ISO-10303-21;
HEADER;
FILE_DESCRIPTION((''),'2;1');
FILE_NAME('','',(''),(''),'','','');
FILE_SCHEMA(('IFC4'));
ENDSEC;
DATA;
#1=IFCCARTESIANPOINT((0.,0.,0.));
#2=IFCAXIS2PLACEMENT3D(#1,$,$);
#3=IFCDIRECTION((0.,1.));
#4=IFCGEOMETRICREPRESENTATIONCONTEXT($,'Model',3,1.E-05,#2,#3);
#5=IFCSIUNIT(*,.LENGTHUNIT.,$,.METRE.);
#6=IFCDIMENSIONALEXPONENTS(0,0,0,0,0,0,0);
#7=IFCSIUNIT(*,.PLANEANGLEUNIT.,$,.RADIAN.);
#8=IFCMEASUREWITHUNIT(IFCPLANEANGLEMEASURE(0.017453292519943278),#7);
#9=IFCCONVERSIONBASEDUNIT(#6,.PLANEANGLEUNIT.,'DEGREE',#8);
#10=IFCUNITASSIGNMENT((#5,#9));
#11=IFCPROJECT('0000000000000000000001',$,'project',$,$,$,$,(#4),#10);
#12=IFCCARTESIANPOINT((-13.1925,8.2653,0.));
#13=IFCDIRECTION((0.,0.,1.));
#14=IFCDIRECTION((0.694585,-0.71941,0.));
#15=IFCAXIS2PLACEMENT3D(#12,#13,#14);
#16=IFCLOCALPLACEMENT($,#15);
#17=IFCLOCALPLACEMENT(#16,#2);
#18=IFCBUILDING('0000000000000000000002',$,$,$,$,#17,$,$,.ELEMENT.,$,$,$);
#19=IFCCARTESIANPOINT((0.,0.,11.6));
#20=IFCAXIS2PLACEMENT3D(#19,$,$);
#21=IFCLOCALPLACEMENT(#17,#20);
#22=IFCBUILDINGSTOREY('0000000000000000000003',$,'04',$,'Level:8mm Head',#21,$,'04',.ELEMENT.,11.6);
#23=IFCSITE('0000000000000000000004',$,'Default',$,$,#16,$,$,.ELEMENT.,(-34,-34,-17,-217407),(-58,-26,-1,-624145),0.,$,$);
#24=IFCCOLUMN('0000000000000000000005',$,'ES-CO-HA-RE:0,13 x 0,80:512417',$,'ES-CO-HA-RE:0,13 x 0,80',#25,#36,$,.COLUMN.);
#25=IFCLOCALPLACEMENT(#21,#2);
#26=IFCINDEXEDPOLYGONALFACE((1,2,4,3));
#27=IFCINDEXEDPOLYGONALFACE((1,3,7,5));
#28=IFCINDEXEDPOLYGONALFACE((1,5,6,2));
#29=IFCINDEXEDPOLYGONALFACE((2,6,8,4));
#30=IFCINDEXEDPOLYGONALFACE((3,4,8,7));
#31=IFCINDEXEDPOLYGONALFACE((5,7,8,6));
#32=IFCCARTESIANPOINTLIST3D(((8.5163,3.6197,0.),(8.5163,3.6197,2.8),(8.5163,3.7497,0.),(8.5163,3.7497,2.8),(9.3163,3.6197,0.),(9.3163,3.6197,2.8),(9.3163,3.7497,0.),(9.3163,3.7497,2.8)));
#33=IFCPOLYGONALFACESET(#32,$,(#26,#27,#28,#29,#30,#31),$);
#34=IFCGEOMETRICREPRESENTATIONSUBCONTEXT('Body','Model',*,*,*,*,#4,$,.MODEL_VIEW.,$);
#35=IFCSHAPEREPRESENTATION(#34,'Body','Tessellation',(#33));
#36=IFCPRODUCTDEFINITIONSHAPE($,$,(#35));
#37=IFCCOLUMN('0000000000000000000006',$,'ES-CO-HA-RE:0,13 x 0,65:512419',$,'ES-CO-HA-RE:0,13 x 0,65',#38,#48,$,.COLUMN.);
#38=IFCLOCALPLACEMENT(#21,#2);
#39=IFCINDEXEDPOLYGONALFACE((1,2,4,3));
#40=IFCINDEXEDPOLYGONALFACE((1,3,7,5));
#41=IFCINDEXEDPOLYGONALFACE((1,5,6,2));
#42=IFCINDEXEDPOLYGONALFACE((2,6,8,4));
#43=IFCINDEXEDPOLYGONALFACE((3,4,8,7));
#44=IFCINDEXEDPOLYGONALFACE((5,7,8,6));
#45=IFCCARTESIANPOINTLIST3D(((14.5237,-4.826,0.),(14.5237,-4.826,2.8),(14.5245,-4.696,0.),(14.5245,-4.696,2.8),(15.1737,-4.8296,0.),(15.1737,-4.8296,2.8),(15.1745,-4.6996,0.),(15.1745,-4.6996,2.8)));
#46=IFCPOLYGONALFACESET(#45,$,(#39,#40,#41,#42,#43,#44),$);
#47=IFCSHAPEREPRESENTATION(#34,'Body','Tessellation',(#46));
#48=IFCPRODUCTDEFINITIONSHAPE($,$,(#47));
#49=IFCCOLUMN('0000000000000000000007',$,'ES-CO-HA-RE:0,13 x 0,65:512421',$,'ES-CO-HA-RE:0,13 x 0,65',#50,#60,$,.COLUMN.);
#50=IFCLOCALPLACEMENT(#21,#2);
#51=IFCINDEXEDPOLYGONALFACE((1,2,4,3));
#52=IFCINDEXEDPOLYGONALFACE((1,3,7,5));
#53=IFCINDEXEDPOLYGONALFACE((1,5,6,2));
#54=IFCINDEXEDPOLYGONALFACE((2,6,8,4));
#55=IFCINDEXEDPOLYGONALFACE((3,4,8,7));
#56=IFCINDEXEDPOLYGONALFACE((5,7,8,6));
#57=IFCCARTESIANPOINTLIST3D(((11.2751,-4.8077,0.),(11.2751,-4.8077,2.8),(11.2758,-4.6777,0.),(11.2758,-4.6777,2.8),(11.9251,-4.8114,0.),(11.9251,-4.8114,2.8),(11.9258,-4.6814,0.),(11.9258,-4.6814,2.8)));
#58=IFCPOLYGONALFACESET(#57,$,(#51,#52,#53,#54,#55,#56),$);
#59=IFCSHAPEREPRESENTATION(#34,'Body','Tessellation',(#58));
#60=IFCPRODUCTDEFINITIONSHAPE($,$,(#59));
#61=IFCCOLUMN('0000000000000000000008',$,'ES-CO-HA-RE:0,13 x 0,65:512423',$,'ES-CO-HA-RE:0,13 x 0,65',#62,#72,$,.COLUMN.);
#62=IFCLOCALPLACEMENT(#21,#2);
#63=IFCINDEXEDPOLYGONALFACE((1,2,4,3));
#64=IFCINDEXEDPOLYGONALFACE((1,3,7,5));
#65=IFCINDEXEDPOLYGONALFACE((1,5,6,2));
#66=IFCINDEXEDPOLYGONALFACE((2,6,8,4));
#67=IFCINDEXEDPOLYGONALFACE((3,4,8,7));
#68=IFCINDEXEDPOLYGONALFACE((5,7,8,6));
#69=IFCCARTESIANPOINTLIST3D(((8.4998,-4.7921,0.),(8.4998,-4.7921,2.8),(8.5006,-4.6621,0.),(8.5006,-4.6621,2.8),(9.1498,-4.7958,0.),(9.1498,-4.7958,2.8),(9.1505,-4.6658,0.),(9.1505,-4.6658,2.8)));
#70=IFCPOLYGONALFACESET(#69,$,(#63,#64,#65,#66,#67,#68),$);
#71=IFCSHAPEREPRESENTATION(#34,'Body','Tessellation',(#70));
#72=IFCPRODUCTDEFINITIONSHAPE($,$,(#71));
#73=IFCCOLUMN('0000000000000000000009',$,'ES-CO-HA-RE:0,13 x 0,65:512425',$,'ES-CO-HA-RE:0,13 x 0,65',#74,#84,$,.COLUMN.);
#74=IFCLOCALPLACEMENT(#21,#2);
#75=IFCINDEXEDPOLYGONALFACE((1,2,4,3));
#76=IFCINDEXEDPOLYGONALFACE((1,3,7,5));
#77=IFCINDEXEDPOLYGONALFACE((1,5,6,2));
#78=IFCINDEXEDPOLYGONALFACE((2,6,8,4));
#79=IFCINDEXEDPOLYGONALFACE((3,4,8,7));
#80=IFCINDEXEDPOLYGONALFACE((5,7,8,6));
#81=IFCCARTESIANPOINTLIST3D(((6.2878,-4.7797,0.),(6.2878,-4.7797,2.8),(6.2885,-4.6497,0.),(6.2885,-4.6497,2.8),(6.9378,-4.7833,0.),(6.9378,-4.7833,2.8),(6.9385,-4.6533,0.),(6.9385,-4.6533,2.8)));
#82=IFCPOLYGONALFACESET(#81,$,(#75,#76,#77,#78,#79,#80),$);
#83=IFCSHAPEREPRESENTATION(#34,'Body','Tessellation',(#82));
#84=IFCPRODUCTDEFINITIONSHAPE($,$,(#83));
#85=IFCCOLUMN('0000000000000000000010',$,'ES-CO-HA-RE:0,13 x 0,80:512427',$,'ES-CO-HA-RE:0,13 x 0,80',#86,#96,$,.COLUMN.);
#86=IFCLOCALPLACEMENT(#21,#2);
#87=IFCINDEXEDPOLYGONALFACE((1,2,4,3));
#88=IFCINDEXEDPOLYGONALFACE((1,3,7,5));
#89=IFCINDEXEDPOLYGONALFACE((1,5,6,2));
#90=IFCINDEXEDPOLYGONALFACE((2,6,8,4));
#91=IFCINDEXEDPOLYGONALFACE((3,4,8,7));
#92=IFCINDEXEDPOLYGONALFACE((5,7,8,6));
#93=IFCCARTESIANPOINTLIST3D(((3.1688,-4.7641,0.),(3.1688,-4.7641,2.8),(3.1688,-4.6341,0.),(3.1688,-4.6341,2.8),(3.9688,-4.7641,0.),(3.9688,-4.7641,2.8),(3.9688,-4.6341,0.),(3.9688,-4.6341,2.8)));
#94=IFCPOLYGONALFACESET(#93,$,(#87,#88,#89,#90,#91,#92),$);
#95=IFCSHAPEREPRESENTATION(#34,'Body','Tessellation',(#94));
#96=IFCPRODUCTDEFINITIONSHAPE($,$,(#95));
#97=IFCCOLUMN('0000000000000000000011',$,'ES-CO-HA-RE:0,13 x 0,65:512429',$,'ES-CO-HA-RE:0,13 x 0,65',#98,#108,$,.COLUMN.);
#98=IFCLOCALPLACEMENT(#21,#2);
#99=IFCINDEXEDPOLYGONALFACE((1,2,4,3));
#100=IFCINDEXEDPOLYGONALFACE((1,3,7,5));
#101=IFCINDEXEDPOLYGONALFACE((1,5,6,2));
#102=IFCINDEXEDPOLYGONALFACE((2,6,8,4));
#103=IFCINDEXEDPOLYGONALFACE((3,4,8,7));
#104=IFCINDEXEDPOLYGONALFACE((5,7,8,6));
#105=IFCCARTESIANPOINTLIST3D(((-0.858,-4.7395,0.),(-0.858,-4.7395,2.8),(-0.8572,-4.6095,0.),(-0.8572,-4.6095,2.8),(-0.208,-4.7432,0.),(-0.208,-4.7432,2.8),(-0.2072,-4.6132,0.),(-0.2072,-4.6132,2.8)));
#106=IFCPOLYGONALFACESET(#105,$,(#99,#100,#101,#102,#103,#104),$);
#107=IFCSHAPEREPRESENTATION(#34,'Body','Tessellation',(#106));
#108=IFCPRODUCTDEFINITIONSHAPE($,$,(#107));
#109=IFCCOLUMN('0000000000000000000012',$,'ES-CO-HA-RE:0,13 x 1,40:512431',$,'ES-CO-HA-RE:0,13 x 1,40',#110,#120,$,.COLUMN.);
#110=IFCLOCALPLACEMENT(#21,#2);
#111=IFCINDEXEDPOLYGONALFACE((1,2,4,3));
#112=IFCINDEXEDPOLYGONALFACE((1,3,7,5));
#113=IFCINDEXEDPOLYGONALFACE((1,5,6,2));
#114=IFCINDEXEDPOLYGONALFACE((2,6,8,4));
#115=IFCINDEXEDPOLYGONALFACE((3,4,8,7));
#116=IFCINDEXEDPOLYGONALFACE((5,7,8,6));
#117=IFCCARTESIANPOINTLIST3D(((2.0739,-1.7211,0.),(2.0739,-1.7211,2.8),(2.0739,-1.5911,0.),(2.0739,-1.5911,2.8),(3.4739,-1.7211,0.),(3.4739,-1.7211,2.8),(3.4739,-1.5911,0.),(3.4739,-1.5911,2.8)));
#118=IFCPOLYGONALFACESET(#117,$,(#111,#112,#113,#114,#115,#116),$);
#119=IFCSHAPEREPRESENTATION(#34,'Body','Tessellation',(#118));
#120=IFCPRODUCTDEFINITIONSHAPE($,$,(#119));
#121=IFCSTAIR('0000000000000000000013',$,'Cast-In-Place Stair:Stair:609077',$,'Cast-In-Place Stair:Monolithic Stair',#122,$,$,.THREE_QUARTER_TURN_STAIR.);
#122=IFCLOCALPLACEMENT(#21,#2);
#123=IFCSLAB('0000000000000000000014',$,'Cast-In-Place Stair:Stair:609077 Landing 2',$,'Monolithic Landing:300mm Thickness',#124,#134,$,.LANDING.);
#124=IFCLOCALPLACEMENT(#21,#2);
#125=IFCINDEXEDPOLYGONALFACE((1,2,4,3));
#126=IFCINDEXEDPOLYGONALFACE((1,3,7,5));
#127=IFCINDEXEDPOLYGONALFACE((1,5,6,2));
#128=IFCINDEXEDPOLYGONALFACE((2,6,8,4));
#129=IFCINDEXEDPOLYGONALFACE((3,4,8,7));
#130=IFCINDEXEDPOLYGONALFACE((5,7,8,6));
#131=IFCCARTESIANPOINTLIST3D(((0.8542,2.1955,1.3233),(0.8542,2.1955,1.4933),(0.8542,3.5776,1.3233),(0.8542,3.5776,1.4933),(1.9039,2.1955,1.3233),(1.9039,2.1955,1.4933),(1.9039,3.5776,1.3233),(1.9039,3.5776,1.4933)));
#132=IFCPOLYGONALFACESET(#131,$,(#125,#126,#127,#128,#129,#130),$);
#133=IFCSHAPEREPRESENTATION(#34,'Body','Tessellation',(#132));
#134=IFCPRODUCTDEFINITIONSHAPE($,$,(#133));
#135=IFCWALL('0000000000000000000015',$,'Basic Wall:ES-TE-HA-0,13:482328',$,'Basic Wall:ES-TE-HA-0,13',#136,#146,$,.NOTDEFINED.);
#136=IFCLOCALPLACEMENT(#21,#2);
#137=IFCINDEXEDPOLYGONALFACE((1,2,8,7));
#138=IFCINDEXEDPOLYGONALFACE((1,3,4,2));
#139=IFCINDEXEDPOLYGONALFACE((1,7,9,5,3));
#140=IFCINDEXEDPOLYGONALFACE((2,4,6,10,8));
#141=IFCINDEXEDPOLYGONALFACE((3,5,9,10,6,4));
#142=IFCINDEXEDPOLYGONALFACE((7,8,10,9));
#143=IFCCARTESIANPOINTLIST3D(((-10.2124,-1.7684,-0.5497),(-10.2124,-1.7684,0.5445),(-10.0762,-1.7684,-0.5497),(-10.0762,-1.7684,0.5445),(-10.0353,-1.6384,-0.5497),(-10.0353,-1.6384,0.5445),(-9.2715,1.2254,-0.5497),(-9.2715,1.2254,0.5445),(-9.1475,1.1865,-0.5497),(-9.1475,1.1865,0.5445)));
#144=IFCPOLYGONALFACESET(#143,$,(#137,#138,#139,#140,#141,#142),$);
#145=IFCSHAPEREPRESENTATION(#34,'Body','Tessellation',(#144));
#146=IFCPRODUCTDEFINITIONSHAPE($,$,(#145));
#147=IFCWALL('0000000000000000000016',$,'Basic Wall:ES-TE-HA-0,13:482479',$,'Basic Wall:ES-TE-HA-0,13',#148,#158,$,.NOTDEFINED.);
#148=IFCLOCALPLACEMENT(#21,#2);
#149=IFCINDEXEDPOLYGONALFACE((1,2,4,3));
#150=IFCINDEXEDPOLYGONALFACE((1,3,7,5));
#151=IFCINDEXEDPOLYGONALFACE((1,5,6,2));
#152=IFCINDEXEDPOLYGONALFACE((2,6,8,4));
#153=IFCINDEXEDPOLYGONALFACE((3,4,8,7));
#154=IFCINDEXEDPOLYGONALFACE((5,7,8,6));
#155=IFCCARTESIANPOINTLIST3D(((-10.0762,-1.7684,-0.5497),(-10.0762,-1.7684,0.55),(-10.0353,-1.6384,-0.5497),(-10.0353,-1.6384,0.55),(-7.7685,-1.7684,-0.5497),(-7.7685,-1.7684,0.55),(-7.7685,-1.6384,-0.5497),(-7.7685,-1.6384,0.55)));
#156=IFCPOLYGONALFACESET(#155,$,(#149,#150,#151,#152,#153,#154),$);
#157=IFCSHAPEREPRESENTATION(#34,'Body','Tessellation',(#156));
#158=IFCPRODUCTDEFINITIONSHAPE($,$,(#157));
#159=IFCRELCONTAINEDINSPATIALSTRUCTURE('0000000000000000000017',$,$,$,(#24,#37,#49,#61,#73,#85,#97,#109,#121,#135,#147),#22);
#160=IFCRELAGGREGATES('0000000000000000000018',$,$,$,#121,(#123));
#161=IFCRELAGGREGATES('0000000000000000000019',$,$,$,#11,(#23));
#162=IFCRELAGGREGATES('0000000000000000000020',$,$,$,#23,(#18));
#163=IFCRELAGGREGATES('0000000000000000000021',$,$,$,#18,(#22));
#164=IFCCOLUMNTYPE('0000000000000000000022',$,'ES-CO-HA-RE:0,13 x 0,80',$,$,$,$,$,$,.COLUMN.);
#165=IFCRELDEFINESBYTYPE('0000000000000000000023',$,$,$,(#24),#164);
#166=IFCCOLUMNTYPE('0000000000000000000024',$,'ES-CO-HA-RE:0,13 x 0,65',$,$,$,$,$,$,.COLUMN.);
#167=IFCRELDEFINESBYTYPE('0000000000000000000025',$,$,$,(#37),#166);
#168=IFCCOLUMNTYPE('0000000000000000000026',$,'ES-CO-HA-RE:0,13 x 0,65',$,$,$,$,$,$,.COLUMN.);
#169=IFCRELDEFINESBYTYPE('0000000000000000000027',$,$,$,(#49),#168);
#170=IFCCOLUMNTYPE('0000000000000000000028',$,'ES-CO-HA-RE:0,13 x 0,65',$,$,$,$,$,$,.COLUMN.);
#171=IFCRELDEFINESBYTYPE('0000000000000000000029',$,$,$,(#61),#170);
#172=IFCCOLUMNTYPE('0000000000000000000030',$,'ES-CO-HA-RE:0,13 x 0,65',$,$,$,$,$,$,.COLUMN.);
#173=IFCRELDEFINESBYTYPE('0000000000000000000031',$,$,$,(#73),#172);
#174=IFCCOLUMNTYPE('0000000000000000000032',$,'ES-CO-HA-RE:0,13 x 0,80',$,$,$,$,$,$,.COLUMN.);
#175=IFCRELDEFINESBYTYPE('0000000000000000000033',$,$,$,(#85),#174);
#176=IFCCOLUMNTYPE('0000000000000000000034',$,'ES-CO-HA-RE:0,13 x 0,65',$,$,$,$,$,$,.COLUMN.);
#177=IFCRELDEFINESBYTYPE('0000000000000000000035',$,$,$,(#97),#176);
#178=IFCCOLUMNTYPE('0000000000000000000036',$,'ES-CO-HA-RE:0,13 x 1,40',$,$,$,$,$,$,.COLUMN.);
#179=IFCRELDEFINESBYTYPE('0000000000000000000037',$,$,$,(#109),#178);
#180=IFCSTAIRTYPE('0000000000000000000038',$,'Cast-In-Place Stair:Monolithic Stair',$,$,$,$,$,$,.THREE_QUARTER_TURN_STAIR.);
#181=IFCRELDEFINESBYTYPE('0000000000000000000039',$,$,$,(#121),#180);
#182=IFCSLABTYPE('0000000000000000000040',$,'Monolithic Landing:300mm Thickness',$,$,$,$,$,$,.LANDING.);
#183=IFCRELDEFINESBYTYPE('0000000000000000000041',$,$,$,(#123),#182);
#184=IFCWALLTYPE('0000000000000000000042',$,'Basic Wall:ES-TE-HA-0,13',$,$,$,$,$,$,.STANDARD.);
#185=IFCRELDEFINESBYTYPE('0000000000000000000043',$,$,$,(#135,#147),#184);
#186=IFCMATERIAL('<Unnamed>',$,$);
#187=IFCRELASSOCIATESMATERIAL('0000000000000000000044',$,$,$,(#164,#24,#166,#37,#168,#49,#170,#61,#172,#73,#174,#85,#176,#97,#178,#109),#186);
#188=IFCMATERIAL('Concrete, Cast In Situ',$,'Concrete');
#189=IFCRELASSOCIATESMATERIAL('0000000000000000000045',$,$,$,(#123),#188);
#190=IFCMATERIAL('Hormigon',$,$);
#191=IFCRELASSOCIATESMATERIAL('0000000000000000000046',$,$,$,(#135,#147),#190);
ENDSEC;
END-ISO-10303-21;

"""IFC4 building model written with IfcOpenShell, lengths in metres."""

from ifc_helpers import new_model, entity, si_unit, converted_unit, direction, frame, origin, place, context, subcontext, project, spatial, indexed_curve, outline, extrude, source, transform, mapped, material, type_object, type_shapes, element, aggregate, save


model = new_model("IFC4")

# Units and contexts
model_context = context("Model", 3, precision=1e-05, world=origin(), true_north=direction((0.0, 1.0)))
body_context = subcontext(model_context, "Body", "Model", "MODEL_VIEW")
ifc_project = project(units=[si_unit("LENGTHUNIT", "METRE"), converted_unit("PLANEANGLEUNIT", "DEGREE", entity("IfcPlaneAngleMeasure", 0.017453292519943278), si_unit("PLANEANGLEUNIT", "RADIAN"), dimensions=[0, 0, 0, 0, 0, 0, 0])], contexts=[model_context])

# Site, building, storey
site_placement = place(None, frame((-13.1925, 8.2653, 0.0), z_axis=(0.0, 0.0, 1.0), x_axis=(0.694585, -0.71941, 0.0)))
site = spatial("IfcSite", under=ifc_project, at=site_placement, Name="Default", CompositionType="ELEMENT", RefLatitude=(-34, -34, -17, -217407), RefLongitude=(-58, -26, -1, -624145), RefElevation=0.0)
building_placement = place(site_placement, origin())
building = spatial("IfcBuilding", under=site, at=building_placement, CompositionType="ELEMENT")
storey_placement = place(building_placement, frame((0.0, 0.0, 11.6)))
storey = spatial("IfcBuildingStorey", under=building, at=storey_placement, Name="04", ObjectType="Level:8mm Head", LongName="04", CompositionType="ELEMENT", Elevation=11.6)

# Columns
ifc_material_1 = material(Name="<Unnamed>")
ifc_material_2 = material(Name="Hormigon")
column_type_1 = type_object("IfcColumnType", Name="ES-CO-HA-RE:0,13 x 0,80", PredefinedType="COLUMN", material=ifc_material_1)
shared_shape_1 = source(origin(), body_context, "Body", "SweptSolid", [
    extrude(outline(indexed_curve([(-0.4, -0.065), (0.4, -0.065), (0.4, 0.065), (-0.4, 0.065), (-0.4, -0.065)], self_intersect=False)), frame((8.9163, 3.6847, 11.6), z_axis=(0.0, 0.0, 1.0), x_axis=(-1.0, 0.0, 0.0)), (0.0, 0.0, 1.0), 2.8),
])
type_shapes(column_type_1, [shared_shape_1])
column_1_placement = place(storey_placement, frame((0.0, 0.0, -11.6)))
element("IfcColumn", 1, at=column_1_placement, inside=storey, type_object=column_type_1, material=ifc_material_1, Name="ES-CO-HA-RE:0,13 x 0,80:512417", ObjectType="ES-CO-HA-RE:0,13 x 0,80", PredefinedType="COLUMN", context=body_context, shape_type="MappedRepresentation", body=[
    mapped(shared_shape_1, transform((0.0, 0.0, 0.0), scale=1.0)),
])
column_type_2 = type_object("IfcColumnType", Name="ES-CO-HA-RE:0,13 x 0,65", PredefinedType="COLUMN", material=ifc_material_1)
shared_shape_2 = source(origin(), body_context, "Body", "SweptSolid", [
    extrude(outline(indexed_curve([(-0.325, -0.065), (0.325, -0.065), (0.325, 0.065), (-0.325, 0.065), (-0.325, -0.065)], self_intersect=False)), frame((14.8491, -4.7628, 11.6), z_axis=(0.0, 0.0, 1.0), x_axis=(-0.999984, 0.005619, 0.0)), (0.0, 0.0, 1.0), 2.8),
])
type_shapes(column_type_2, [shared_shape_2])
column_2_placement = place(storey_placement, frame((0.0, 0.0, -11.6)))
element("IfcColumn", 2, at=column_2_placement, inside=storey, type_object=column_type_2, material=ifc_material_1, Name="ES-CO-HA-RE:0,13 x 0,65:512419", ObjectType="ES-CO-HA-RE:0,13 x 0,65", PredefinedType="COLUMN", context=body_context, shape_type="MappedRepresentation", body=[
    mapped(shared_shape_2, transform((0.0, 0.0, 0.0), scale=1.0)),
])
column_type_3 = type_object("IfcColumnType", Name="ES-CO-HA-RE:0,13 x 0,65", PredefinedType="COLUMN", material=ifc_material_1)
shared_shape_3 = source(origin(), body_context, "Body", "SweptSolid", [
    extrude(outline(indexed_curve([(-0.325, -0.065), (0.325, -0.065), (0.325, 0.065), (-0.325, 0.065), (-0.325, -0.065)], self_intersect=False)), frame((11.6005, -4.7445, 11.6), z_axis=(0.0, 0.0, 1.0), x_axis=(-0.999984, 0.005619, 0.0)), (0.0, 0.0, 1.0), 2.8),
])
type_shapes(column_type_3, [shared_shape_3])
column_3_placement = place(storey_placement, frame((0.0, 0.0, -11.6)))
element("IfcColumn", 3, at=column_3_placement, inside=storey, type_object=column_type_3, material=ifc_material_1, Name="ES-CO-HA-RE:0,13 x 0,65:512421", ObjectType="ES-CO-HA-RE:0,13 x 0,65", PredefinedType="COLUMN", context=body_context, shape_type="MappedRepresentation", body=[
    mapped(shared_shape_3, transform((0.0, 0.0, 0.0), scale=1.0)),
])
column_type_4 = type_object("IfcColumnType", Name="ES-CO-HA-RE:0,13 x 0,65", PredefinedType="COLUMN", material=ifc_material_1)
shared_shape_4 = source(origin(), body_context, "Body", "SweptSolid", [
    extrude(outline(indexed_curve([(-0.325, -0.065), (0.325, -0.065), (0.325, 0.065), (-0.325, 0.065), (-0.325, -0.065)], self_intersect=False)), frame((8.8252, -4.7289, 11.6), z_axis=(0.0, 0.0, 1.0), x_axis=(-0.999984, 0.005619, 0.0)), (0.0, 0.0, 1.0), 2.8),
])
type_shapes(column_type_4, [shared_shape_4])
column_4_placement = place(storey_placement, frame((0.0, 0.0, -11.6)))
element("IfcColumn", 4, at=column_4_placement, inside=storey, type_object=column_type_4, material=ifc_material_1, Name="ES-CO-HA-RE:0,13 x 0,65:512423", ObjectType="ES-CO-HA-RE:0,13 x 0,65", PredefinedType="COLUMN", context=body_context, shape_type="MappedRepresentation", body=[
    mapped(shared_shape_4, transform((0.0, 0.0, 0.0), scale=1.0)),
])
column_type_5 = type_object("IfcColumnType", Name="ES-CO-HA-RE:0,13 x 0,65", PredefinedType="COLUMN", material=ifc_material_1)
shared_shape_5 = source(origin(), body_context, "Body", "SweptSolid", [
    extrude(outline(indexed_curve([(-0.325, -0.065), (0.325, -0.065), (0.325, 0.065), (-0.325, 0.065), (-0.325, -0.065)], self_intersect=False)), frame((6.6131, -4.7165, 11.6), z_axis=(0.0, 0.0, 1.0), x_axis=(-0.999984, 0.005619, 0.0)), (0.0, 0.0, 1.0), 2.8),
])
type_shapes(column_type_5, [shared_shape_5])
column_5_placement = place(storey_placement, frame((0.0, 0.0, -11.6)))
element("IfcColumn", 5, at=column_5_placement, inside=storey, type_object=column_type_5, material=ifc_material_1, Name="ES-CO-HA-RE:0,13 x 0,65:512425", ObjectType="ES-CO-HA-RE:0,13 x 0,65", PredefinedType="COLUMN", context=body_context, shape_type="MappedRepresentation", body=[
    mapped(shared_shape_5, transform((0.0, 0.0, 0.0), scale=1.0)),
])
column_type_6 = type_object("IfcColumnType", Name="ES-CO-HA-RE:0,13 x 0,80", PredefinedType="COLUMN", material=ifc_material_1)
shared_shape_6 = source(origin(), body_context, "Body", "SweptSolid", [
    extrude(outline(indexed_curve([(-0.4, -0.065), (0.4, -0.065), (0.4, 0.065), (-0.4, 0.065), (-0.4, -0.065)], self_intersect=False)), frame((3.5688, -4.6991, 11.6), z_axis=(0.0, 0.0, 1.0), x_axis=(-1.0, 0.0, 0.0)), (0.0, 0.0, 1.0), 2.8),
])
type_shapes(column_type_6, [shared_shape_6])
column_6_placement = place(storey_placement, frame((0.0, 0.0, -11.6)))
element("IfcColumn", 6, at=column_6_placement, inside=storey, type_object=column_type_6, material=ifc_material_1, Name="ES-CO-HA-RE:0,13 x 0,80:512427", ObjectType="ES-CO-HA-RE:0,13 x 0,80", PredefinedType="COLUMN", context=body_context, shape_type="MappedRepresentation", body=[
    mapped(shared_shape_6, transform((0.0, 0.0, 0.0), scale=1.0)),
])
column_type_7 = type_object("IfcColumnType", Name="ES-CO-HA-RE:0,13 x 0,65", PredefinedType="COLUMN", material=ifc_material_1)
shared_shape_7 = source(origin(), body_context, "Body", "SweptSolid", [
    extrude(outline(indexed_curve([(-0.325, -0.065), (0.325, -0.065), (0.325, 0.065), (-0.325, 0.065), (-0.325, -0.065)], self_intersect=False)), frame((-0.5326, -4.6764, 11.6), z_axis=(0.0, 0.0, 1.0), x_axis=(-0.999984, 0.005619, 0.0)), (0.0, 0.0, 1.0), 2.8),
])
type_shapes(column_type_7, [shared_shape_7])
column_7_placement = place(storey_placement, frame((0.0, 0.0, -11.6)))
element("IfcColumn", 7, at=column_7_placement, inside=storey, type_object=column_type_7, material=ifc_material_1, Name="ES-CO-HA-RE:0,13 x 0,65:512429", ObjectType="ES-CO-HA-RE:0,13 x 0,65", PredefinedType="COLUMN", context=body_context, shape_type="MappedRepresentation", body=[
    mapped(shared_shape_7, transform((0.0, 0.0, 0.0), scale=1.0)),
])
column_type_8 = type_object("IfcColumnType", Name="ES-CO-HA-RE:0,13 x 1,40", PredefinedType="COLUMN", material=ifc_material_1)
shared_shape_8 = source(origin(), body_context, "Body", "SweptSolid", [
    extrude(outline(indexed_curve([(-0.7, -0.065), (0.7, -0.065), (0.7, 0.065), (-0.7, 0.065), (-0.7, -0.065)], self_intersect=False)), frame((2.7739, -1.6561, 11.6), z_axis=(0.0, 0.0, 1.0), x_axis=(-1.0, 0.0, 0.0)), (0.0, 0.0, 1.0), 2.8),
])
type_shapes(column_type_8, [shared_shape_8])
column_8_placement = place(storey_placement, frame((0.0, 0.0, -11.6)))
element("IfcColumn", 8, at=column_8_placement, inside=storey, type_object=column_type_8, material=ifc_material_1, Name="ES-CO-HA-RE:0,13 x 1,40:512431", ObjectType="ES-CO-HA-RE:0,13 x 1,40", PredefinedType="COLUMN", context=body_context, shape_type="MappedRepresentation", body=[
    mapped(shared_shape_8, transform((0.0, 0.0, 0.0), scale=1.0)),
])

# Stair, slab
stair_type = type_object("IfcStairType", Name="Cast-In-Place Stair:Monolithic Stair", PredefinedType="THREE_QUARTER_TURN_STAIR")
stair_placement = place(storey_placement, origin())
stair = element("IfcStair", 9, at=stair_placement, inside=storey, type_object=stair_type, Name="Cast-In-Place Stair:Stair:609077", ObjectType="Cast-In-Place Stair:Monolithic Stair", PredefinedType="THREE_QUARTER_TURN_STAIR")
ifc_material_3 = material(Name="Concrete, Cast In Situ", Category="Concrete")
slab_type = type_object("IfcSlabType", Name="Monolithic Landing:300mm Thickness", PredefinedType="LANDING")
slab_1_placement = place(stair_placement, origin())
slab_1 = element("IfcSlab", 10, at=slab_1_placement, type_object=slab_type, material=ifc_material_3, Name="Cast-In-Place Stair:Stair:609077 Landing 2", ObjectType="Monolithic Landing:300mm Thickness", PredefinedType="LANDING", context=body_context, shape_type="SweptSolid", body=[
    extrude(outline(indexed_curve([(-0.6911, -0.5249), (0.6911, -0.5249), (0.6911, 0.5249), (-0.6911, 0.5249), (-0.6911, -0.5249)], self_intersect=False)), frame((1.379, 2.8866, 1.3233), z_axis=(0.0, 0.0, 1.0), x_axis=(0.0, 1.0, 0.0)), (0.0, 0.0, 1.0), 0.17),
])

# Walls
wall_type = type_object("IfcWallType", Name="Basic Wall:ES-TE-HA-0,13", PredefinedType="STANDARD")
wall_1_placement = place(storey_placement, frame((-10.1504, -1.7879, -0.5497), z_axis=(0.0, 0.0, 1.0), x_axis=(0.299835, 0.953991, 0.0)))
element("IfcWall", 11, at=wall_1_placement, inside=storey, type_object=wall_type, material=ifc_material_2, Name="Basic Wall:ES-TE-HA-0,13:482328", ObjectType="Basic Wall:ES-TE-HA-0,13", PredefinedType="NOTDEFINED", context=body_context, shape_type="SweptSolid", body=[
    extrude(outline(indexed_curve([(3.1382, -0.065), (3.1382, 0.065), (0.0, 0.065), (0.0409, -0.065), (0.1771, -0.065), (3.1382, -0.065)], self_intersect=False)), origin(), (0.0, 0.0, 1.0), 1.0942),
])
wall_2_placement = place(storey_placement, frame((-10.0762, -1.7034, -0.5497)))
element("IfcWall", 12, at=wall_2_placement, inside=storey, type_object=wall_type, material=ifc_material_2, Name="Basic Wall:ES-TE-HA-0,13:482479", ObjectType="Basic Wall:ES-TE-HA-0,13", PredefinedType="NOTDEFINED", context=body_context, shape_type="SweptSolid", body=[
    extrude(outline(indexed_curve([(2.3077, -0.065), (2.3077, 0.065), (0.0409, 0.065), (0.0, -0.065), (2.3077, -0.065)], self_intersect=False)), origin(), (0.0, 0.0, 1.0), 1.0997),
])

aggregate(stair, [slab_1])

save(model, "model.ifc")
